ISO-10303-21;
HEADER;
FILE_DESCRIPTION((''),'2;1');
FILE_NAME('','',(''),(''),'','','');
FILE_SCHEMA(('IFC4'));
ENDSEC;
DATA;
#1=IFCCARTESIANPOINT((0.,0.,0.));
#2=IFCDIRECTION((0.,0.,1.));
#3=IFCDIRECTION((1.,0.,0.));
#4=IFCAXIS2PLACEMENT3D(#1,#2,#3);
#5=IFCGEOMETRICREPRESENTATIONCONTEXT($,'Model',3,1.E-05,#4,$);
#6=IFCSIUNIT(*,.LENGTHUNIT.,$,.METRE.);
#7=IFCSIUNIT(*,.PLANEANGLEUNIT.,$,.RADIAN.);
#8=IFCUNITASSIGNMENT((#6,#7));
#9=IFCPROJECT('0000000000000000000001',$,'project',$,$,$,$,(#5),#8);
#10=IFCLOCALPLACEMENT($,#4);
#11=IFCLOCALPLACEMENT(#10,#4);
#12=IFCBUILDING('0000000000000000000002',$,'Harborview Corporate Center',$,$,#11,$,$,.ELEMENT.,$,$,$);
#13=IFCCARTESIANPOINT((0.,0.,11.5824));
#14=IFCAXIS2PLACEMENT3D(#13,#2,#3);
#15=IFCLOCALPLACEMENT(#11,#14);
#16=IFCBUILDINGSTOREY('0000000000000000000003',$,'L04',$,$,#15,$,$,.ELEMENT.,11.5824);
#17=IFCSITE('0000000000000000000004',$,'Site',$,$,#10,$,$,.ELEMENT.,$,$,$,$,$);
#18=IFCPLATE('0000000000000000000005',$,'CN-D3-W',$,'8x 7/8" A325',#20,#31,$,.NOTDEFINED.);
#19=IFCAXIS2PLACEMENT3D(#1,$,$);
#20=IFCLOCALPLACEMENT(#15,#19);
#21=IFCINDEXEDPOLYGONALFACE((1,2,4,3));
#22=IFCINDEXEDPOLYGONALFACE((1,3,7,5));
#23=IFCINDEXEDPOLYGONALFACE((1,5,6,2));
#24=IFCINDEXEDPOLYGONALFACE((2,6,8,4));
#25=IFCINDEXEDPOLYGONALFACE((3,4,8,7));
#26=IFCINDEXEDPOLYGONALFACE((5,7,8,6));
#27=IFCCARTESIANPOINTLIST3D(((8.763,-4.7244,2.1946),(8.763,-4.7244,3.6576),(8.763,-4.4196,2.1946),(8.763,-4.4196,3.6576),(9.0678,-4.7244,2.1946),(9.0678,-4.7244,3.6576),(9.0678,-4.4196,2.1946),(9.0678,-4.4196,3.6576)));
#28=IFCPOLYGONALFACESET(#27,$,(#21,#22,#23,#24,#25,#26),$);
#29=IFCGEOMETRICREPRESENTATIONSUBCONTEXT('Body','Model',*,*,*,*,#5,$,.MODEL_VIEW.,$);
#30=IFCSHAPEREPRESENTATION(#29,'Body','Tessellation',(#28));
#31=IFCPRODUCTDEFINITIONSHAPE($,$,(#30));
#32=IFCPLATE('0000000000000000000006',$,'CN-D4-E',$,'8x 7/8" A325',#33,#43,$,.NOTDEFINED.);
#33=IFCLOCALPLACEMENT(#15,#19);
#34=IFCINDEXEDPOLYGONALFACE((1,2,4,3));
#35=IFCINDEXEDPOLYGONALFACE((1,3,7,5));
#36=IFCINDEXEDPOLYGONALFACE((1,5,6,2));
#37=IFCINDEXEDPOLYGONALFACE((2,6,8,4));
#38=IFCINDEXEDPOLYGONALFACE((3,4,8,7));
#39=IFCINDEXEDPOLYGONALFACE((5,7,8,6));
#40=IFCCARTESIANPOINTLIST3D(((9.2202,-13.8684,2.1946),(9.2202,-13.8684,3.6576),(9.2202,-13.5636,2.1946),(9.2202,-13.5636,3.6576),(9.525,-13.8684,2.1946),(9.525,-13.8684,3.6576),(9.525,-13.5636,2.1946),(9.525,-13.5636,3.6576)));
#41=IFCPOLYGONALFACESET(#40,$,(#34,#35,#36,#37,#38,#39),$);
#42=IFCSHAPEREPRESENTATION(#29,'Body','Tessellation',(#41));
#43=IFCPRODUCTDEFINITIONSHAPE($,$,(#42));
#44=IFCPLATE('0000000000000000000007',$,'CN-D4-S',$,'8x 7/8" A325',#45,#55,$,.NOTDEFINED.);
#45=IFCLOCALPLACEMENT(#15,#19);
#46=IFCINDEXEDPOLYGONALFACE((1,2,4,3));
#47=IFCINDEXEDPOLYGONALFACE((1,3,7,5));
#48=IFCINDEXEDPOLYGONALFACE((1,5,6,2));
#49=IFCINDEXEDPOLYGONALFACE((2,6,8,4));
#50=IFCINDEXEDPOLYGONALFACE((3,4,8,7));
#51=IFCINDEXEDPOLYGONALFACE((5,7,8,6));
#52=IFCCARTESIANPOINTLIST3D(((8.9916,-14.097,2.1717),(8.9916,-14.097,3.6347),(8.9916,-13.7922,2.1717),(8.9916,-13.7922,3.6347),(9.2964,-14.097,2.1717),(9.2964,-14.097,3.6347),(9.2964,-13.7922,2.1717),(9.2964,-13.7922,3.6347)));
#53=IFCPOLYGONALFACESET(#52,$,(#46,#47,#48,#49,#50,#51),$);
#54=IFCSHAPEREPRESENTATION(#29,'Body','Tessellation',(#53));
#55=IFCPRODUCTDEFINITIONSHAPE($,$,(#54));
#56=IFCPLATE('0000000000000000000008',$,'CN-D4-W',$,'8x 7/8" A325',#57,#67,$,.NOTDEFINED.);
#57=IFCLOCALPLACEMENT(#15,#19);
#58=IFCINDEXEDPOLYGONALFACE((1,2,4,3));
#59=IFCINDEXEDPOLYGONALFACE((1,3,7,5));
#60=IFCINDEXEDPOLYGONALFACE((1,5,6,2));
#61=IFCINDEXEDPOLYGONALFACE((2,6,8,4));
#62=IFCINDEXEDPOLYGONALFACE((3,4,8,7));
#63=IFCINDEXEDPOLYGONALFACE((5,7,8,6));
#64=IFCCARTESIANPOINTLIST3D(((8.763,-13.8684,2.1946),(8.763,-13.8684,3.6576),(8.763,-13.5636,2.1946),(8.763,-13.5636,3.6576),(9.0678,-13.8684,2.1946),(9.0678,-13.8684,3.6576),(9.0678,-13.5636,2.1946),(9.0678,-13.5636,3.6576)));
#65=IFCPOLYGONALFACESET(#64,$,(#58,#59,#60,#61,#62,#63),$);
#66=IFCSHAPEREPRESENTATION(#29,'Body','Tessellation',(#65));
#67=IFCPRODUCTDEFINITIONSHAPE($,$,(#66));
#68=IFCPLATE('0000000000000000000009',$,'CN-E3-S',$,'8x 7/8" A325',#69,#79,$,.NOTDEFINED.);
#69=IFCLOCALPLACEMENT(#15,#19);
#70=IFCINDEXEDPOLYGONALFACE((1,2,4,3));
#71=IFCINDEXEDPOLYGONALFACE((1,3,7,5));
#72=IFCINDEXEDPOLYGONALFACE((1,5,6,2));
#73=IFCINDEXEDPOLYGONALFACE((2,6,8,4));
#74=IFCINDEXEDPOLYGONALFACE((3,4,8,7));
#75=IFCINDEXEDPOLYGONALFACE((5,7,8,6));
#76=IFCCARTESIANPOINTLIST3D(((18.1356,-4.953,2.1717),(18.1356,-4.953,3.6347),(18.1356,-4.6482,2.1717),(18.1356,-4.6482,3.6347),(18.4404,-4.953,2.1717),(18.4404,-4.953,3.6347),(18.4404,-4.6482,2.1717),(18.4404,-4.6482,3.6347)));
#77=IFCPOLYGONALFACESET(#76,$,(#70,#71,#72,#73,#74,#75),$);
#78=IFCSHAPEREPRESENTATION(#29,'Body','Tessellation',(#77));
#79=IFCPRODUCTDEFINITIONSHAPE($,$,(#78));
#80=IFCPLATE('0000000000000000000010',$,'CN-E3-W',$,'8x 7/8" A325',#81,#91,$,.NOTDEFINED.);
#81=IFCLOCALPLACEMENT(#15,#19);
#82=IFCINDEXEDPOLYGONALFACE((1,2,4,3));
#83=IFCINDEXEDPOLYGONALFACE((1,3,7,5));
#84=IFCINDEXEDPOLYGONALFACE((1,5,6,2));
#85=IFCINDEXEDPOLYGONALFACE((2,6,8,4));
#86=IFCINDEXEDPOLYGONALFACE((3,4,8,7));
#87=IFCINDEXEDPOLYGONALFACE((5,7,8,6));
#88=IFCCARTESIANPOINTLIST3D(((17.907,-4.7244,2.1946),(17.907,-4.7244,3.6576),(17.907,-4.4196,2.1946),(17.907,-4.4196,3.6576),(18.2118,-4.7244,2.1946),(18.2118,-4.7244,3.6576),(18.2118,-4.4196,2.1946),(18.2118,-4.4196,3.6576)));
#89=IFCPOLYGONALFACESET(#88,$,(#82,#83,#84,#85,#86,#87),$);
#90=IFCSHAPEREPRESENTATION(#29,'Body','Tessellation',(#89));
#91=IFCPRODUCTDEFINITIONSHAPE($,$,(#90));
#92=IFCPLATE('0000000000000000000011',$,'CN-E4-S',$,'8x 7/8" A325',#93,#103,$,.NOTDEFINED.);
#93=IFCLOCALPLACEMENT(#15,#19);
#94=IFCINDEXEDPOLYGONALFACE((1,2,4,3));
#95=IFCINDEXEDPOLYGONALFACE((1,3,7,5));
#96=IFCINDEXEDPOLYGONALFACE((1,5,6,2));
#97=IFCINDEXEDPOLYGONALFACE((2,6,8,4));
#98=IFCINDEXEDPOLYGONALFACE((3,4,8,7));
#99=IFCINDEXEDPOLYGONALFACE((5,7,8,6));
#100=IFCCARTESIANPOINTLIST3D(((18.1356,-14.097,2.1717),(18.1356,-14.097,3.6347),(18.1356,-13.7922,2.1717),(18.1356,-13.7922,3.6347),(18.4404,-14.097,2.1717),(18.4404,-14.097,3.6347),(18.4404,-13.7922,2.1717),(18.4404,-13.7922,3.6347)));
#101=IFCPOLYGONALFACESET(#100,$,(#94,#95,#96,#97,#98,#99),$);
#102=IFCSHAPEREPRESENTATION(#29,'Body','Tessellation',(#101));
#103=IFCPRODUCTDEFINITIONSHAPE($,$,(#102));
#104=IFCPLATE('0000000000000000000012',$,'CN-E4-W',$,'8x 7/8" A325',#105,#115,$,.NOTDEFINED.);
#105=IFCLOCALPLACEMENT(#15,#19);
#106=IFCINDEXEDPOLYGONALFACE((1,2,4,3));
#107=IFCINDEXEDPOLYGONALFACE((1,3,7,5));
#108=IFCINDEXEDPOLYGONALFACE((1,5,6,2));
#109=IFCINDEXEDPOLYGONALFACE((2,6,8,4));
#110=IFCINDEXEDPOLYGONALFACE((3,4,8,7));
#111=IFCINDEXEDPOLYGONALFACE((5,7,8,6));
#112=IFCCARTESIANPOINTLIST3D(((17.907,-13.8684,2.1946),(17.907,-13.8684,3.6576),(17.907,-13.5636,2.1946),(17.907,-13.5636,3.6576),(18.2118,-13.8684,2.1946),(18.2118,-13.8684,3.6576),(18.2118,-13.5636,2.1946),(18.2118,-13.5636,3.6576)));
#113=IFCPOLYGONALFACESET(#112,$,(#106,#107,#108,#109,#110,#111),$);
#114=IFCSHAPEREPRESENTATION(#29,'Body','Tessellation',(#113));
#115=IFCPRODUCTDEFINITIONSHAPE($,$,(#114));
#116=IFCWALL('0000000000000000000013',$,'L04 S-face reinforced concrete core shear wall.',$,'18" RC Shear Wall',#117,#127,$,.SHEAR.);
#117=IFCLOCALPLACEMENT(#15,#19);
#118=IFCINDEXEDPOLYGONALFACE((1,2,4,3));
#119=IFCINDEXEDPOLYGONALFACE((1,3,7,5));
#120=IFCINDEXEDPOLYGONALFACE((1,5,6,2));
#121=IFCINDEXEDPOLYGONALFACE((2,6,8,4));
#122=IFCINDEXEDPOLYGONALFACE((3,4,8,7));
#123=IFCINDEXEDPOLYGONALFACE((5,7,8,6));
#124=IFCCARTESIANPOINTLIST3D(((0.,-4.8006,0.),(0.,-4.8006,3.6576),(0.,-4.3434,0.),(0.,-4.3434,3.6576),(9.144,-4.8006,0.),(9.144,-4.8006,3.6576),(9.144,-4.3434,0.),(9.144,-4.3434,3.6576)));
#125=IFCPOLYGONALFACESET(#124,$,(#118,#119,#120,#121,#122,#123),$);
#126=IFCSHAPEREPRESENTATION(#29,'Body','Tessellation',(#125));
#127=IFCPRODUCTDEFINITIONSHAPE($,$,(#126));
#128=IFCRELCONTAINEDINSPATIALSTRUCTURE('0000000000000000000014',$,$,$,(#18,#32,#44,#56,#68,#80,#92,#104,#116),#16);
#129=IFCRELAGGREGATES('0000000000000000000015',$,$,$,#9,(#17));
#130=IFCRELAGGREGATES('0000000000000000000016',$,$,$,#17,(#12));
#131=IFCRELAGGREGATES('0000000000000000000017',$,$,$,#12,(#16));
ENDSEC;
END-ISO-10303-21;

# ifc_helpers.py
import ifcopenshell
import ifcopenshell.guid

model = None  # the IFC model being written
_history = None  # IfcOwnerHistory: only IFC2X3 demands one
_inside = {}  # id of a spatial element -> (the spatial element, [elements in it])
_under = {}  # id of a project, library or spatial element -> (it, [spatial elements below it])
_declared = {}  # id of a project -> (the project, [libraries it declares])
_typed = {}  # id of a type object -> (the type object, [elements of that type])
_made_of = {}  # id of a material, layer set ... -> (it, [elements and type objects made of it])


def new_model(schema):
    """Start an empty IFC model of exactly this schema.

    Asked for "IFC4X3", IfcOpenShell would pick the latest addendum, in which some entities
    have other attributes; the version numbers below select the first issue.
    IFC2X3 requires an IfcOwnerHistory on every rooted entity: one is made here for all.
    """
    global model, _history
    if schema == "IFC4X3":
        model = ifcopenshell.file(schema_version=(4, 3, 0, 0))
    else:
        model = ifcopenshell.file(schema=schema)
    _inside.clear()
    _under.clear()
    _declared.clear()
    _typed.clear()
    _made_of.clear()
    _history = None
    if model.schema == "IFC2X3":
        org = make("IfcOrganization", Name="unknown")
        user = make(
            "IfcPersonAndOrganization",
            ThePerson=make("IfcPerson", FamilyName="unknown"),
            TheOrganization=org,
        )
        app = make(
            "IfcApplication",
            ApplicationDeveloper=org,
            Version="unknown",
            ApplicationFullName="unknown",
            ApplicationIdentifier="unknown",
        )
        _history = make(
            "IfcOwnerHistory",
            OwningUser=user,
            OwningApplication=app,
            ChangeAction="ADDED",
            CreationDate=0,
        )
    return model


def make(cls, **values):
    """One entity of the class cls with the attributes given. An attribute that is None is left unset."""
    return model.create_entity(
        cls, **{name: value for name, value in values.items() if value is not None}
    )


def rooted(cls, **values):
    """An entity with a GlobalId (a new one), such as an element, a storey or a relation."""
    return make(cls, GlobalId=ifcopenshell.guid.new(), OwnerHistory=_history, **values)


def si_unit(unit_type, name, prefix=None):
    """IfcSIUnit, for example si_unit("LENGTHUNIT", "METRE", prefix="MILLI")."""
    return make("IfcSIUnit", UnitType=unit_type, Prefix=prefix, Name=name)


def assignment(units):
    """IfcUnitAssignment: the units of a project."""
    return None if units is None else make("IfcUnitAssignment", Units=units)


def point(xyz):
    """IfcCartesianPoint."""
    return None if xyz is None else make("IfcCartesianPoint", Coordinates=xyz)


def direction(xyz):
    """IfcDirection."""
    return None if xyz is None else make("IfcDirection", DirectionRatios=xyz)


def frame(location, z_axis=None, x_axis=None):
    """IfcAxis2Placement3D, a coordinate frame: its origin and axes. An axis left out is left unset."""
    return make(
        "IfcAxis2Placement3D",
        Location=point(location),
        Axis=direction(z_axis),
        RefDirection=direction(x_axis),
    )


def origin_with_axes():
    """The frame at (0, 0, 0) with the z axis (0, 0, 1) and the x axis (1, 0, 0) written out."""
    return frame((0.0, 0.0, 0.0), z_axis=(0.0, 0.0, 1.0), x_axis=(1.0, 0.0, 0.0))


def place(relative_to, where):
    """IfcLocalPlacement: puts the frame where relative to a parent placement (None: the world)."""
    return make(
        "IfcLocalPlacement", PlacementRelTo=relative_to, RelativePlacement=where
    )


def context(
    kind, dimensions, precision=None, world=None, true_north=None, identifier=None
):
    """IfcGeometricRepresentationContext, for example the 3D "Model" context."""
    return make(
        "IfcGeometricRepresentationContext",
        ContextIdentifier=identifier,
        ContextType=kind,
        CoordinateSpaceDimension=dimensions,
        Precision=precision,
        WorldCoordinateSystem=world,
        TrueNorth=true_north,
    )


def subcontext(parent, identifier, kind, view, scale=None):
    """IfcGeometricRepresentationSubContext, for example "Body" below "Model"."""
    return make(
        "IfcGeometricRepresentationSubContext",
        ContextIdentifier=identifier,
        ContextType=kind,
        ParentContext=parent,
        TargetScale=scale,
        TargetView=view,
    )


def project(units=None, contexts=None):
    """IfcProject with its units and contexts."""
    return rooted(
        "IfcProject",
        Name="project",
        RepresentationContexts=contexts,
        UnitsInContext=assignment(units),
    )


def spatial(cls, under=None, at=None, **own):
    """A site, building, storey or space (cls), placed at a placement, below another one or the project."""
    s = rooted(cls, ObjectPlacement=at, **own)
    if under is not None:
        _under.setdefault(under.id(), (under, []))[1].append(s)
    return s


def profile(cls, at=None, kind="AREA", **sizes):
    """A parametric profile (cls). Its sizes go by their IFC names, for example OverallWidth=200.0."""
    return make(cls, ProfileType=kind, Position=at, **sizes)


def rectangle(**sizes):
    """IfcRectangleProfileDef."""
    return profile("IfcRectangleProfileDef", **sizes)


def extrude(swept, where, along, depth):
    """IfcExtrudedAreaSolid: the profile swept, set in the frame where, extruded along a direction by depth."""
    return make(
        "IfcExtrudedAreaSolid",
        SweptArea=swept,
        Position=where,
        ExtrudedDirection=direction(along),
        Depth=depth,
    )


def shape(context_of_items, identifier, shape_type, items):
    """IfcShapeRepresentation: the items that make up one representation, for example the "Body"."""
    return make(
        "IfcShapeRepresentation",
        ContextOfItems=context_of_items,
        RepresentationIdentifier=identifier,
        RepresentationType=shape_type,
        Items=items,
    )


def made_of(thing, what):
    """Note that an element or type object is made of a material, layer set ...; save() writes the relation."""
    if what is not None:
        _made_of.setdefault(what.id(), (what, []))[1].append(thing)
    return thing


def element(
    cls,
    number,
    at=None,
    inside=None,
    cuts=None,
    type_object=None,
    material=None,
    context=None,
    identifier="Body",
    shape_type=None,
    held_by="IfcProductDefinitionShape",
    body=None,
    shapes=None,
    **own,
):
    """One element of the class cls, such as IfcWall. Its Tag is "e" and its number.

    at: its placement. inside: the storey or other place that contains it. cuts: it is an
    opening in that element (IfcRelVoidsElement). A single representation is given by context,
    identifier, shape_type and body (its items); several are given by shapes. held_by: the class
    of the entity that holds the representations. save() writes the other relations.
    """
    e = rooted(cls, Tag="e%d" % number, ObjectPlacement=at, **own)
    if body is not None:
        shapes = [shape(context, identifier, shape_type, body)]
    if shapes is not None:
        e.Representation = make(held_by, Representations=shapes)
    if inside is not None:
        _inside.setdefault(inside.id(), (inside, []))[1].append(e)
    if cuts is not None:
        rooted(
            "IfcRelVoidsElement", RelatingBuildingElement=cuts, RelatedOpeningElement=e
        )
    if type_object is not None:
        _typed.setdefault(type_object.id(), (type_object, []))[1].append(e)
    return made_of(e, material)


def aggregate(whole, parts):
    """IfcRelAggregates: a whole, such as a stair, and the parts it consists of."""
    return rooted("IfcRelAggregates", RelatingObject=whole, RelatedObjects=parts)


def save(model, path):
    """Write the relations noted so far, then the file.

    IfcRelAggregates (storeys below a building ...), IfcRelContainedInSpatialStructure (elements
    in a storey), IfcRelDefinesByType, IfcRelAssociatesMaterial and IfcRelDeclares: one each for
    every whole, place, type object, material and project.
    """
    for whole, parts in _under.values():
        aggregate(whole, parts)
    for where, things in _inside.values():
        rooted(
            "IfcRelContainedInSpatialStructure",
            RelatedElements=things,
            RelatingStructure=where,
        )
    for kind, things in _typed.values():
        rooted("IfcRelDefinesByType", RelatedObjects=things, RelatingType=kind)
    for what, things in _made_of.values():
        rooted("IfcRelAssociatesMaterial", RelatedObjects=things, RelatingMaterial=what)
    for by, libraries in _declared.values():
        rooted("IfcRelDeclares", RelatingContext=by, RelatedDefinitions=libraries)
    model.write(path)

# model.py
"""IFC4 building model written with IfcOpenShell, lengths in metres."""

from ifc_helpers import new_model, si_unit, frame, origin_with_axes, place, context, subcontext, project, spatial, rectangle, extrude, element, save


model = new_model("IFC4")

# Units and contexts
model_context = context("Model", 3, precision=1e-05, world=origin_with_axes())
body_context = subcontext(model_context, "Body", "Model", "MODEL_VIEW")
ifc_project = project(units=[si_unit("LENGTHUNIT", "METRE"), si_unit("PLANEANGLEUNIT", "RADIAN")], contexts=[model_context])

# Site, building, storey
site_placement = place(None, origin_with_axes())
site = spatial("IfcSite", under=ifc_project, at=site_placement, Name="Site", CompositionType="ELEMENT")
building_placement = place(site_placement, origin_with_axes())
building = spatial("IfcBuilding", under=site, at=building_placement, Name="Harborview Corporate Center", CompositionType="ELEMENT")
storey_placement = place(building_placement, frame((0.0, 0.0, 11.5824), z_axis=(0.0, 0.0, 1.0), x_axis=(1.0, 0.0, 0.0)))
storey = spatial("IfcBuildingStorey", under=building, at=storey_placement, Name="L04", CompositionType="ELEMENT", Elevation=11.5824)

# Plates
for number, where, z_axis, x_axis, name in (
    (1, (8.9154, -4.572, 2.1946), (0.0, 0.0, 1.0), (1.0, 0.0, 0.0), "CN-D3-W"),
    (2, (9.3726, -13.716, 2.1946), (0.0, 0.0, 1.0), (1.0, 0.0, 0.0), "CN-D4-E"),
    (3, (9.144, -13.9446, 2.1717), (0.0, 0.0, 1.0), (1.0, 0.0, 0.0), "CN-D4-S"),
    (4, (8.9154, -13.716, 2.1946), (0.0, 0.0, 1.0), (1.0, 0.0, 0.0), "CN-D4-W"),
    (5, (18.288, -4.8006, 2.1717), (0.0, 0.0, 1.0), (1.0, 0.0, 0.0), "CN-E3-S"),
    (6, (18.0594, -4.572, 2.1946), (0.0, 0.0, 1.0), (1.0, 0.0, 0.0), "CN-E3-W"),
    (7, (18.288, -13.9446, 2.1717), (0.0, 0.0, 1.0), (1.0, 0.0, 0.0), "CN-E4-S"),
    (8, (18.0594, -13.716, 2.1946), (0.0, 0.0, 1.0), (1.0, 0.0, 0.0), "CN-E4-W"),
):
    element("IfcPlate", number, at=place(storey_placement, frame(where, z_axis=z_axis, x_axis=x_axis)), inside=storey, Name=name, ObjectType="8x 7/8\" A325", PredefinedType="NOTDEFINED", context=body_context, shape_type="SweptSolid", body=[
        extrude(rectangle(XDim=0.3048, YDim=0.3048), origin_with_axes(), (0.0, 0.0, 1.0), 1.463),
    ])

# Wall
wall_placement = place(storey_placement, frame((4.572, -4.572, 0.0), z_axis=(0.0, 0.0, 1.0), x_axis=(1.0, 0.0, 0.0)))
element("IfcWall", 9, at=wall_placement, inside=storey, Name="L04 S-face reinforced concrete core shear wall.", ObjectType="18\" RC Shear Wall", PredefinedType="SHEAR", context=body_context, shape_type="SweptSolid", body=[
    extrude(rectangle(XDim=9.144, YDim=0.4572), origin_with_axes(), (0.0, 0.0, 1.0), 3.6576),
])

save(model, "model.ifc")
